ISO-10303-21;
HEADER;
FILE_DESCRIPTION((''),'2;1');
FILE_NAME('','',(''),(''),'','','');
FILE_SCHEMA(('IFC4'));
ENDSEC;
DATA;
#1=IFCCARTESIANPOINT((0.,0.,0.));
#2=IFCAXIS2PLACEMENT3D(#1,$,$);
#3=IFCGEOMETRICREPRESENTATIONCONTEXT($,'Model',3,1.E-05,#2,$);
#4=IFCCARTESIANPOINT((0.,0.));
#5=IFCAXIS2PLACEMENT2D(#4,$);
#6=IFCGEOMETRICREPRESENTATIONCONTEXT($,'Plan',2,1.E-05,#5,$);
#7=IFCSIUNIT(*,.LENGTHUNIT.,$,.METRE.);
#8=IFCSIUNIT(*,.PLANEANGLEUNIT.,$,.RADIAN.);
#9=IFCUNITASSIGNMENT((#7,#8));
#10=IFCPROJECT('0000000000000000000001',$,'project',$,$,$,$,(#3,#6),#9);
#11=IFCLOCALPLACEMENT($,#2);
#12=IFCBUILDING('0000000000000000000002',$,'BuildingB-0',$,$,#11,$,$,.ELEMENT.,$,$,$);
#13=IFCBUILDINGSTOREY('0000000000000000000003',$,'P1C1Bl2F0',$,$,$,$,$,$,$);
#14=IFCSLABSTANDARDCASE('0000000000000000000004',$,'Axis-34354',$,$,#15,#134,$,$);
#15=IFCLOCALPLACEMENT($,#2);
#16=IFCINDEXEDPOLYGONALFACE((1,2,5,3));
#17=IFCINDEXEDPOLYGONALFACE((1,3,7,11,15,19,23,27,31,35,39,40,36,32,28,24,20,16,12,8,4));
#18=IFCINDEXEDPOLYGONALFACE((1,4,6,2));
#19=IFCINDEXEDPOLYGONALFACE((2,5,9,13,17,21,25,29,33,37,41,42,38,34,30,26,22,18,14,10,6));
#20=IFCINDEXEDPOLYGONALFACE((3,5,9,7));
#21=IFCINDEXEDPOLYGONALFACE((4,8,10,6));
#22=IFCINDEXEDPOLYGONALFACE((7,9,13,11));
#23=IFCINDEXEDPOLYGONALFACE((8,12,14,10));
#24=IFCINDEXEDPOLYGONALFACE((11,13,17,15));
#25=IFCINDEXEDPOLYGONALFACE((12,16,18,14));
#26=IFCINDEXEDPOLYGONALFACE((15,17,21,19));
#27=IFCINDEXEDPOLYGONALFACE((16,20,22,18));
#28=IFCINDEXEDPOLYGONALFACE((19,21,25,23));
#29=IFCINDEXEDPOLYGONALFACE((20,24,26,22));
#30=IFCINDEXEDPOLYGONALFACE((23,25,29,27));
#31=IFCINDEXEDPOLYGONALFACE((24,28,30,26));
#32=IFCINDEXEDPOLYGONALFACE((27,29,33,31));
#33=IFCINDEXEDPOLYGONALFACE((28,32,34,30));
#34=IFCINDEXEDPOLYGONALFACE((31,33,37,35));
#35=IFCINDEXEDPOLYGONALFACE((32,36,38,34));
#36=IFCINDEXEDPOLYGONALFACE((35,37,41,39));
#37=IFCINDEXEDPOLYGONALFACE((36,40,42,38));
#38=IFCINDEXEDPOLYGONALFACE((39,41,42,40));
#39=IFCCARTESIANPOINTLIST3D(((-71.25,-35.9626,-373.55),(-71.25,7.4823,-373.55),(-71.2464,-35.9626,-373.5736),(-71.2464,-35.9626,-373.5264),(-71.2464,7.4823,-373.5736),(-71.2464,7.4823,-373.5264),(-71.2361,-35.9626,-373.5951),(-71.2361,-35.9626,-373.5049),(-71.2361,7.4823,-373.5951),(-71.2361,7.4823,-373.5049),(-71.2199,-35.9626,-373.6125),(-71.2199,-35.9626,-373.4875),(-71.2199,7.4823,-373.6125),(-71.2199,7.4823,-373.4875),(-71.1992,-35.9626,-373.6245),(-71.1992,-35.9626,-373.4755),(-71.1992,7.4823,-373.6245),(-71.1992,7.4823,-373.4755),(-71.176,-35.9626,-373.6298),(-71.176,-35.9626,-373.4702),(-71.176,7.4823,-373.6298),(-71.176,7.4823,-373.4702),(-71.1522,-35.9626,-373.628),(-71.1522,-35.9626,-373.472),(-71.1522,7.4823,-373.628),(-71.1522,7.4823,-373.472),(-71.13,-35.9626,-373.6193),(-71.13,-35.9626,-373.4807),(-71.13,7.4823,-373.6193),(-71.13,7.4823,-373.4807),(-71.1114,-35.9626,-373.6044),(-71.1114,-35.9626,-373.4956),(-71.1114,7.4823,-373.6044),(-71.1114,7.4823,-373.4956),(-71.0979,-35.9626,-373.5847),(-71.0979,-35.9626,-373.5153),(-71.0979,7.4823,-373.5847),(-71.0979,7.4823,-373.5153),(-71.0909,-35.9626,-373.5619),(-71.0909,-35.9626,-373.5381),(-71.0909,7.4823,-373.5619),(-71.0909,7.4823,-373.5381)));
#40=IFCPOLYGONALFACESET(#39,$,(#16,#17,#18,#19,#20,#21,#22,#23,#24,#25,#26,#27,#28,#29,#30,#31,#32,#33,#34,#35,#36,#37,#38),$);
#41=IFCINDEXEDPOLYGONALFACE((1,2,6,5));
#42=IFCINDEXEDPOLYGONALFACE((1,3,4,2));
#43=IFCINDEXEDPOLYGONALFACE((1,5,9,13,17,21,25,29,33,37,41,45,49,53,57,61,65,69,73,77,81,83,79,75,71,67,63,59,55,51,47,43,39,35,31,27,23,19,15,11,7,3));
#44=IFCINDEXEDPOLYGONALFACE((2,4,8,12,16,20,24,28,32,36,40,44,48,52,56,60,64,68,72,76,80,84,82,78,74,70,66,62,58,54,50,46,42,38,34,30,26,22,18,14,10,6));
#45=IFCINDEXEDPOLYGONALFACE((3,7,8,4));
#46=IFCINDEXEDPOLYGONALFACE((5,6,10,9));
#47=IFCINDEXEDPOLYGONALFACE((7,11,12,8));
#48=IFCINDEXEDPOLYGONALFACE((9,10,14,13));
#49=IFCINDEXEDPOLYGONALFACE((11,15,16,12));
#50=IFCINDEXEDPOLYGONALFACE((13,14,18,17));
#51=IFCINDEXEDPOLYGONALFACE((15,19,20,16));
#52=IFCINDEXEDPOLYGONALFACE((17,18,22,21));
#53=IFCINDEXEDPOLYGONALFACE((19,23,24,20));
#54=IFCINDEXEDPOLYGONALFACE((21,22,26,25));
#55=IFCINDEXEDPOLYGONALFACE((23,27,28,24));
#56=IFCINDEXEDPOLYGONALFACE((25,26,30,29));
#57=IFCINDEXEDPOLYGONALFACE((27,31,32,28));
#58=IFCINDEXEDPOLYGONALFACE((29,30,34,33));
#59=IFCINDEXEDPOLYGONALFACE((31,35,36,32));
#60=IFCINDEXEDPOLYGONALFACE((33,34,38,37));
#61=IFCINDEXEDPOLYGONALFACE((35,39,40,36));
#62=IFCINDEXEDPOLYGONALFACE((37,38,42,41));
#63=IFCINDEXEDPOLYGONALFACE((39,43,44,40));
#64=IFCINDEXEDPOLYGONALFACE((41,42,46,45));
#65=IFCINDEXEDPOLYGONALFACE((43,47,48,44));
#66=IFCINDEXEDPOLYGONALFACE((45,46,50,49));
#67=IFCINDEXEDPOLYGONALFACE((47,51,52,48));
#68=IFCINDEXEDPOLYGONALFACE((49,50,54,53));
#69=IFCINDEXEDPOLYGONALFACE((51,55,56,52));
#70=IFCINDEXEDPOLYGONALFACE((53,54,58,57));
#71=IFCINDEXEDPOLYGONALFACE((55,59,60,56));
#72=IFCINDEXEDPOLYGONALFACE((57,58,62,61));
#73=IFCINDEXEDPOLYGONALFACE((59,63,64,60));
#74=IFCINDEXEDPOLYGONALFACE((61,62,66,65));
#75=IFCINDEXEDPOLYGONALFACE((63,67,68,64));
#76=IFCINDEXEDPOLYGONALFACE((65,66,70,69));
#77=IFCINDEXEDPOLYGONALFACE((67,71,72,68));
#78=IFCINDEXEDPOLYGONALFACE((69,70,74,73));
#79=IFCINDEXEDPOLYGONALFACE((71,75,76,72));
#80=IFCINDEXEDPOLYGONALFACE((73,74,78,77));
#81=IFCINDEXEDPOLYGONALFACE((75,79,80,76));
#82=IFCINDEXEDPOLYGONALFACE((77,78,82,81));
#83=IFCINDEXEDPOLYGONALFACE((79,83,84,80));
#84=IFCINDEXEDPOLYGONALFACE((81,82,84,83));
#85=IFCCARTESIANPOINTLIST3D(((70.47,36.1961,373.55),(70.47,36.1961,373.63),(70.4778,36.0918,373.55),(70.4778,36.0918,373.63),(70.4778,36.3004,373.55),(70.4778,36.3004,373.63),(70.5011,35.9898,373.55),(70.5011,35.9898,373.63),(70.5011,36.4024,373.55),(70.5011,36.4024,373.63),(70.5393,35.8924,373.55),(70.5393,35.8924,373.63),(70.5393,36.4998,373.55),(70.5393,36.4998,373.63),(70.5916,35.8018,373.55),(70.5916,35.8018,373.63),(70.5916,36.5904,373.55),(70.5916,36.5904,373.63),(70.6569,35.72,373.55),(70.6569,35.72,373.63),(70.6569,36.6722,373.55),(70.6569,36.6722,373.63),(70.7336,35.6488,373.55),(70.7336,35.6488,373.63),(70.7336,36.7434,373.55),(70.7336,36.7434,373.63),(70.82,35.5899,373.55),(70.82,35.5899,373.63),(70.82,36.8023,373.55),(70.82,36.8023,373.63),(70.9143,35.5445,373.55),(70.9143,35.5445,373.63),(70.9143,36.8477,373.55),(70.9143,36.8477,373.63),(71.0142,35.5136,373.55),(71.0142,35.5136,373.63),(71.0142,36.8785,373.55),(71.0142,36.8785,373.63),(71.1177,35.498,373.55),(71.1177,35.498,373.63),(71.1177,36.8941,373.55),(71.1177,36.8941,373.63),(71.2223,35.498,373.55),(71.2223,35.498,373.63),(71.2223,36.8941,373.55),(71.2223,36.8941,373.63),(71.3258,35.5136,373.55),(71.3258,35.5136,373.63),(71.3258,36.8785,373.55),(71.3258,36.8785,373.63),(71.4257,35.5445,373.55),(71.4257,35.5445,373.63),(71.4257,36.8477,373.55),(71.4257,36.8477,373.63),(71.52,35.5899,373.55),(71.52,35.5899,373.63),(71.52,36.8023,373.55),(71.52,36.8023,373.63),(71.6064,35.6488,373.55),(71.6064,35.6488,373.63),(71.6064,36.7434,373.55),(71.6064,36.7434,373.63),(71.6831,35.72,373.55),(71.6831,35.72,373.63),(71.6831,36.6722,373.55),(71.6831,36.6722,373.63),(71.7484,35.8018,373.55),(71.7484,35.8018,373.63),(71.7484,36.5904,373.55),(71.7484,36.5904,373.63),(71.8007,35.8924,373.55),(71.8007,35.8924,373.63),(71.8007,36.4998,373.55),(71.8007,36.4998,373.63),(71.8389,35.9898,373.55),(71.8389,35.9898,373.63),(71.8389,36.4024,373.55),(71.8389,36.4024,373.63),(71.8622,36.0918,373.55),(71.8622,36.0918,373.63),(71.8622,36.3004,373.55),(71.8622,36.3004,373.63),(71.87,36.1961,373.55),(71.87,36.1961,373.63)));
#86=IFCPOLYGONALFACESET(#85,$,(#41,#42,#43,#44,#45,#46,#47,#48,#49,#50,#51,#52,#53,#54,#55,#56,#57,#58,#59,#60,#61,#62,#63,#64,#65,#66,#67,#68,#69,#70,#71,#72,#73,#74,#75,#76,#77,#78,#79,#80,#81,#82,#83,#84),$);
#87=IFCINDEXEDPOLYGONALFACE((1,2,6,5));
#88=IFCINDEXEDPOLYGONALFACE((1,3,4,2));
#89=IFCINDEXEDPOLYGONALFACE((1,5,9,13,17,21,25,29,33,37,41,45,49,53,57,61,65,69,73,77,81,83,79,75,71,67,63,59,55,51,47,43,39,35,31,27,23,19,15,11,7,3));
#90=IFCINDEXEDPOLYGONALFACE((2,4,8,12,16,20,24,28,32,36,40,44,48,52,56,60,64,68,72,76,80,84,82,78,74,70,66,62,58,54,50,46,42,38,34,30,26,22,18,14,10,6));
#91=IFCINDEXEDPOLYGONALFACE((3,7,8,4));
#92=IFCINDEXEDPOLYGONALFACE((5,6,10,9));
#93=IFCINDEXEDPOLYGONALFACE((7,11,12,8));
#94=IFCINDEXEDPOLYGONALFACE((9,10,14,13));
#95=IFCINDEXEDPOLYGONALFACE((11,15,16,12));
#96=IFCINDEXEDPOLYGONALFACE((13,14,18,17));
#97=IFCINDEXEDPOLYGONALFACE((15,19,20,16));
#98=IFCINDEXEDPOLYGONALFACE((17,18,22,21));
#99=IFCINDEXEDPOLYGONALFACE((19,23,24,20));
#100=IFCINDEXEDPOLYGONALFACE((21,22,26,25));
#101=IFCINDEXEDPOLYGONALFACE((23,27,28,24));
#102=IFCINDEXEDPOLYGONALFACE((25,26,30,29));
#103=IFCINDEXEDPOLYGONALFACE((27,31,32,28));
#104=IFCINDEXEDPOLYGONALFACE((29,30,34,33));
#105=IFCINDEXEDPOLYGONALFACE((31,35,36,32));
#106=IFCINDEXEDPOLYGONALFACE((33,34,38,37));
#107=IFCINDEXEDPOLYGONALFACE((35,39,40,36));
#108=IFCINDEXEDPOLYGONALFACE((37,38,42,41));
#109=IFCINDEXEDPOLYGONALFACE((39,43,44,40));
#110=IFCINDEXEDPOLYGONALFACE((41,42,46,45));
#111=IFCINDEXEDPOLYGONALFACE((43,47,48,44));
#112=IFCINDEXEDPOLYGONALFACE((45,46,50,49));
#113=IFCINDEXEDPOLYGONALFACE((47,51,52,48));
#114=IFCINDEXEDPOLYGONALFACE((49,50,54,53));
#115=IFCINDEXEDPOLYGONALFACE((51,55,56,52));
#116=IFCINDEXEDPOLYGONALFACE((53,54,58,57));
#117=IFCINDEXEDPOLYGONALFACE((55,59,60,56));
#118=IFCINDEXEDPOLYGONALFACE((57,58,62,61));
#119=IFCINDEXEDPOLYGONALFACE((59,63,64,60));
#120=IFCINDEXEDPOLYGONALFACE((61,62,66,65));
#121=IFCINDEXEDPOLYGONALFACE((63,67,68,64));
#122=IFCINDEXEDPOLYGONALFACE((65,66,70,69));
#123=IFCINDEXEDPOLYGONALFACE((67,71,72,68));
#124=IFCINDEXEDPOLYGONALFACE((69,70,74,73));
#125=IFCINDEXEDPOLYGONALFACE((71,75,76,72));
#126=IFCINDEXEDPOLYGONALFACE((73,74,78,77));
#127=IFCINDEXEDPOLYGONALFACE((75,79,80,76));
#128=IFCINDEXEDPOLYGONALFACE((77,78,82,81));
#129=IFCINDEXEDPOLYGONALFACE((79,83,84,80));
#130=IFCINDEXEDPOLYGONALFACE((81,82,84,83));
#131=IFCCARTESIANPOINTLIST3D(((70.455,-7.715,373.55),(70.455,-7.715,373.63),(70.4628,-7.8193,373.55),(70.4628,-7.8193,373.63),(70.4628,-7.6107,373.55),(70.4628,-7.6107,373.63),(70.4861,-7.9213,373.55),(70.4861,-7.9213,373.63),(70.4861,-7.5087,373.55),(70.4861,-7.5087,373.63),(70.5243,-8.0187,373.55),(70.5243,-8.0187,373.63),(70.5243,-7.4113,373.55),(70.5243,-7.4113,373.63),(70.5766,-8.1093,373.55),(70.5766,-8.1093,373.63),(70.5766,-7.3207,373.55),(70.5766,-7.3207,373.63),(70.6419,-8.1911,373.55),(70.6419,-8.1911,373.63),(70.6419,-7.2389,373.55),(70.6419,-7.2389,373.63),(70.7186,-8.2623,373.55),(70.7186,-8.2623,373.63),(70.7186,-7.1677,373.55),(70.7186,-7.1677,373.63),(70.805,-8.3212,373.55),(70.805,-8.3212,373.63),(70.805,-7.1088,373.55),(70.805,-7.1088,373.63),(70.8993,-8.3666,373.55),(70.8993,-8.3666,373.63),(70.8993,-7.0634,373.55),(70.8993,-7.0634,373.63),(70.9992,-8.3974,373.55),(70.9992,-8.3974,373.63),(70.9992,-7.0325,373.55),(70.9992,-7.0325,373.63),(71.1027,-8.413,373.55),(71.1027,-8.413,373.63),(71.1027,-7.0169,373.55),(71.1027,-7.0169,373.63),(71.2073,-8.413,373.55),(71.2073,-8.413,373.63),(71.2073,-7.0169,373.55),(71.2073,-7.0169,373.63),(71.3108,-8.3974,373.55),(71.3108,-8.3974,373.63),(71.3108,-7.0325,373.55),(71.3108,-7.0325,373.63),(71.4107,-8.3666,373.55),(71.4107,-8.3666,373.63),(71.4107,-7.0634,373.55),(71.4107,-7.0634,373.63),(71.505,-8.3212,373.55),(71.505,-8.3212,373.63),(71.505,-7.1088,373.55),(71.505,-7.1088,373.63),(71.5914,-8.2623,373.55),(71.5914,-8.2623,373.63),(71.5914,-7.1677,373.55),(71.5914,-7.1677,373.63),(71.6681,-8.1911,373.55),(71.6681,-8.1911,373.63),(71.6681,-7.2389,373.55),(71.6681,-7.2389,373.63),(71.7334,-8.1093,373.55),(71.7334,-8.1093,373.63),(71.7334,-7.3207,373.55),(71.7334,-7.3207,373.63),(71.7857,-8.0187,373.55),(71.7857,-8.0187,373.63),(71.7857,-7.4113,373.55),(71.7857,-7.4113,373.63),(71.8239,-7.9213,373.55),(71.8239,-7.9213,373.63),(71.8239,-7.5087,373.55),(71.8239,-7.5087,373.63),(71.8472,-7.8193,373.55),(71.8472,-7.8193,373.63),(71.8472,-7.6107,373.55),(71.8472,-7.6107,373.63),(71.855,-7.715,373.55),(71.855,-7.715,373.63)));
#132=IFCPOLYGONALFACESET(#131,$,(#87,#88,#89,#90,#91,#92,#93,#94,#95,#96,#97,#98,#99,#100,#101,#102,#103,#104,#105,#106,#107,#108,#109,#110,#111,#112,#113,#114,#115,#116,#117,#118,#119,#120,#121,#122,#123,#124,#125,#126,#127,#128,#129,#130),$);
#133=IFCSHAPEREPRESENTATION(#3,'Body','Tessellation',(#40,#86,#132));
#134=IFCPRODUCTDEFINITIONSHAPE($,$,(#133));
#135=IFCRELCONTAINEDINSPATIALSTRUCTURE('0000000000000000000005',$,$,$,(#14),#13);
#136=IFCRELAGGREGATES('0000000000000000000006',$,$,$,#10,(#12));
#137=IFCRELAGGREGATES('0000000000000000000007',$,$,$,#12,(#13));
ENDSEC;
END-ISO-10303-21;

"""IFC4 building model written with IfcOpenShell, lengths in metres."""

from ifc_helpers import new_model, entity, si_unit, frame, origin, origin_2d, place, context, project, spatial, circle, extrude, element, save


model = new_model("IFC4")

# Units and contexts
model_context = context("Model", 3, precision=1e-05, world=origin())
plan_context = context("Plan", 2, precision=1e-05, world=origin_2d())
ifc_project = project(units=[si_unit("LENGTHUNIT", "METRE"), si_unit("PLANEANGLEUNIT", "RADIAN")], contexts=[model_context, plan_context])

# Building, storey
building_placement = place(None, origin())
building = spatial("IfcBuilding", under=ifc_project, at=building_placement, Name="BuildingB-0", CompositionType="ELEMENT")
storey = spatial("IfcBuildingStorey", under=building, Name="P1C1Bl2F0")

# Slab
element("IfcSlabStandardCase", 1, inside=storey, Name="Axis-34354", context=model_context, shape_type="AdvancedSweptSolid", body=[
    entity("IfcSurfaceCurveSweptAreaSolid", entity("IfcCircleProfileDef", "AREA", None, None, 0.08), None, entity("IfcPolyline", [entity("IfcCartesianPoint", [71.17, 35.9626, 373.55]), entity("IfcCartesianPoint", [71.17, -7.4823, 373.55])]), None, None, entity("IfcPlane", entity("IfcAxis2Placement3D", entity("IfcCartesianPoint", [71.17, 35.9626, 373.55]), entity("IfcDirection", [0.0, 0.0, 1.0]), entity("IfcDirection", [1.0, 0.0, 0.0])))),
    extrude(circle(Radius=0.7), frame((71.17, 36.1961, 373.55)), (0.0, 0.0, 1.0), 0.08),
    extrude(circle(Radius=0.7), frame((71.155, -7.715, 373.55)), (0.0, 0.0, 1.0), 0.08),
])

save(model, "model.ifc")
